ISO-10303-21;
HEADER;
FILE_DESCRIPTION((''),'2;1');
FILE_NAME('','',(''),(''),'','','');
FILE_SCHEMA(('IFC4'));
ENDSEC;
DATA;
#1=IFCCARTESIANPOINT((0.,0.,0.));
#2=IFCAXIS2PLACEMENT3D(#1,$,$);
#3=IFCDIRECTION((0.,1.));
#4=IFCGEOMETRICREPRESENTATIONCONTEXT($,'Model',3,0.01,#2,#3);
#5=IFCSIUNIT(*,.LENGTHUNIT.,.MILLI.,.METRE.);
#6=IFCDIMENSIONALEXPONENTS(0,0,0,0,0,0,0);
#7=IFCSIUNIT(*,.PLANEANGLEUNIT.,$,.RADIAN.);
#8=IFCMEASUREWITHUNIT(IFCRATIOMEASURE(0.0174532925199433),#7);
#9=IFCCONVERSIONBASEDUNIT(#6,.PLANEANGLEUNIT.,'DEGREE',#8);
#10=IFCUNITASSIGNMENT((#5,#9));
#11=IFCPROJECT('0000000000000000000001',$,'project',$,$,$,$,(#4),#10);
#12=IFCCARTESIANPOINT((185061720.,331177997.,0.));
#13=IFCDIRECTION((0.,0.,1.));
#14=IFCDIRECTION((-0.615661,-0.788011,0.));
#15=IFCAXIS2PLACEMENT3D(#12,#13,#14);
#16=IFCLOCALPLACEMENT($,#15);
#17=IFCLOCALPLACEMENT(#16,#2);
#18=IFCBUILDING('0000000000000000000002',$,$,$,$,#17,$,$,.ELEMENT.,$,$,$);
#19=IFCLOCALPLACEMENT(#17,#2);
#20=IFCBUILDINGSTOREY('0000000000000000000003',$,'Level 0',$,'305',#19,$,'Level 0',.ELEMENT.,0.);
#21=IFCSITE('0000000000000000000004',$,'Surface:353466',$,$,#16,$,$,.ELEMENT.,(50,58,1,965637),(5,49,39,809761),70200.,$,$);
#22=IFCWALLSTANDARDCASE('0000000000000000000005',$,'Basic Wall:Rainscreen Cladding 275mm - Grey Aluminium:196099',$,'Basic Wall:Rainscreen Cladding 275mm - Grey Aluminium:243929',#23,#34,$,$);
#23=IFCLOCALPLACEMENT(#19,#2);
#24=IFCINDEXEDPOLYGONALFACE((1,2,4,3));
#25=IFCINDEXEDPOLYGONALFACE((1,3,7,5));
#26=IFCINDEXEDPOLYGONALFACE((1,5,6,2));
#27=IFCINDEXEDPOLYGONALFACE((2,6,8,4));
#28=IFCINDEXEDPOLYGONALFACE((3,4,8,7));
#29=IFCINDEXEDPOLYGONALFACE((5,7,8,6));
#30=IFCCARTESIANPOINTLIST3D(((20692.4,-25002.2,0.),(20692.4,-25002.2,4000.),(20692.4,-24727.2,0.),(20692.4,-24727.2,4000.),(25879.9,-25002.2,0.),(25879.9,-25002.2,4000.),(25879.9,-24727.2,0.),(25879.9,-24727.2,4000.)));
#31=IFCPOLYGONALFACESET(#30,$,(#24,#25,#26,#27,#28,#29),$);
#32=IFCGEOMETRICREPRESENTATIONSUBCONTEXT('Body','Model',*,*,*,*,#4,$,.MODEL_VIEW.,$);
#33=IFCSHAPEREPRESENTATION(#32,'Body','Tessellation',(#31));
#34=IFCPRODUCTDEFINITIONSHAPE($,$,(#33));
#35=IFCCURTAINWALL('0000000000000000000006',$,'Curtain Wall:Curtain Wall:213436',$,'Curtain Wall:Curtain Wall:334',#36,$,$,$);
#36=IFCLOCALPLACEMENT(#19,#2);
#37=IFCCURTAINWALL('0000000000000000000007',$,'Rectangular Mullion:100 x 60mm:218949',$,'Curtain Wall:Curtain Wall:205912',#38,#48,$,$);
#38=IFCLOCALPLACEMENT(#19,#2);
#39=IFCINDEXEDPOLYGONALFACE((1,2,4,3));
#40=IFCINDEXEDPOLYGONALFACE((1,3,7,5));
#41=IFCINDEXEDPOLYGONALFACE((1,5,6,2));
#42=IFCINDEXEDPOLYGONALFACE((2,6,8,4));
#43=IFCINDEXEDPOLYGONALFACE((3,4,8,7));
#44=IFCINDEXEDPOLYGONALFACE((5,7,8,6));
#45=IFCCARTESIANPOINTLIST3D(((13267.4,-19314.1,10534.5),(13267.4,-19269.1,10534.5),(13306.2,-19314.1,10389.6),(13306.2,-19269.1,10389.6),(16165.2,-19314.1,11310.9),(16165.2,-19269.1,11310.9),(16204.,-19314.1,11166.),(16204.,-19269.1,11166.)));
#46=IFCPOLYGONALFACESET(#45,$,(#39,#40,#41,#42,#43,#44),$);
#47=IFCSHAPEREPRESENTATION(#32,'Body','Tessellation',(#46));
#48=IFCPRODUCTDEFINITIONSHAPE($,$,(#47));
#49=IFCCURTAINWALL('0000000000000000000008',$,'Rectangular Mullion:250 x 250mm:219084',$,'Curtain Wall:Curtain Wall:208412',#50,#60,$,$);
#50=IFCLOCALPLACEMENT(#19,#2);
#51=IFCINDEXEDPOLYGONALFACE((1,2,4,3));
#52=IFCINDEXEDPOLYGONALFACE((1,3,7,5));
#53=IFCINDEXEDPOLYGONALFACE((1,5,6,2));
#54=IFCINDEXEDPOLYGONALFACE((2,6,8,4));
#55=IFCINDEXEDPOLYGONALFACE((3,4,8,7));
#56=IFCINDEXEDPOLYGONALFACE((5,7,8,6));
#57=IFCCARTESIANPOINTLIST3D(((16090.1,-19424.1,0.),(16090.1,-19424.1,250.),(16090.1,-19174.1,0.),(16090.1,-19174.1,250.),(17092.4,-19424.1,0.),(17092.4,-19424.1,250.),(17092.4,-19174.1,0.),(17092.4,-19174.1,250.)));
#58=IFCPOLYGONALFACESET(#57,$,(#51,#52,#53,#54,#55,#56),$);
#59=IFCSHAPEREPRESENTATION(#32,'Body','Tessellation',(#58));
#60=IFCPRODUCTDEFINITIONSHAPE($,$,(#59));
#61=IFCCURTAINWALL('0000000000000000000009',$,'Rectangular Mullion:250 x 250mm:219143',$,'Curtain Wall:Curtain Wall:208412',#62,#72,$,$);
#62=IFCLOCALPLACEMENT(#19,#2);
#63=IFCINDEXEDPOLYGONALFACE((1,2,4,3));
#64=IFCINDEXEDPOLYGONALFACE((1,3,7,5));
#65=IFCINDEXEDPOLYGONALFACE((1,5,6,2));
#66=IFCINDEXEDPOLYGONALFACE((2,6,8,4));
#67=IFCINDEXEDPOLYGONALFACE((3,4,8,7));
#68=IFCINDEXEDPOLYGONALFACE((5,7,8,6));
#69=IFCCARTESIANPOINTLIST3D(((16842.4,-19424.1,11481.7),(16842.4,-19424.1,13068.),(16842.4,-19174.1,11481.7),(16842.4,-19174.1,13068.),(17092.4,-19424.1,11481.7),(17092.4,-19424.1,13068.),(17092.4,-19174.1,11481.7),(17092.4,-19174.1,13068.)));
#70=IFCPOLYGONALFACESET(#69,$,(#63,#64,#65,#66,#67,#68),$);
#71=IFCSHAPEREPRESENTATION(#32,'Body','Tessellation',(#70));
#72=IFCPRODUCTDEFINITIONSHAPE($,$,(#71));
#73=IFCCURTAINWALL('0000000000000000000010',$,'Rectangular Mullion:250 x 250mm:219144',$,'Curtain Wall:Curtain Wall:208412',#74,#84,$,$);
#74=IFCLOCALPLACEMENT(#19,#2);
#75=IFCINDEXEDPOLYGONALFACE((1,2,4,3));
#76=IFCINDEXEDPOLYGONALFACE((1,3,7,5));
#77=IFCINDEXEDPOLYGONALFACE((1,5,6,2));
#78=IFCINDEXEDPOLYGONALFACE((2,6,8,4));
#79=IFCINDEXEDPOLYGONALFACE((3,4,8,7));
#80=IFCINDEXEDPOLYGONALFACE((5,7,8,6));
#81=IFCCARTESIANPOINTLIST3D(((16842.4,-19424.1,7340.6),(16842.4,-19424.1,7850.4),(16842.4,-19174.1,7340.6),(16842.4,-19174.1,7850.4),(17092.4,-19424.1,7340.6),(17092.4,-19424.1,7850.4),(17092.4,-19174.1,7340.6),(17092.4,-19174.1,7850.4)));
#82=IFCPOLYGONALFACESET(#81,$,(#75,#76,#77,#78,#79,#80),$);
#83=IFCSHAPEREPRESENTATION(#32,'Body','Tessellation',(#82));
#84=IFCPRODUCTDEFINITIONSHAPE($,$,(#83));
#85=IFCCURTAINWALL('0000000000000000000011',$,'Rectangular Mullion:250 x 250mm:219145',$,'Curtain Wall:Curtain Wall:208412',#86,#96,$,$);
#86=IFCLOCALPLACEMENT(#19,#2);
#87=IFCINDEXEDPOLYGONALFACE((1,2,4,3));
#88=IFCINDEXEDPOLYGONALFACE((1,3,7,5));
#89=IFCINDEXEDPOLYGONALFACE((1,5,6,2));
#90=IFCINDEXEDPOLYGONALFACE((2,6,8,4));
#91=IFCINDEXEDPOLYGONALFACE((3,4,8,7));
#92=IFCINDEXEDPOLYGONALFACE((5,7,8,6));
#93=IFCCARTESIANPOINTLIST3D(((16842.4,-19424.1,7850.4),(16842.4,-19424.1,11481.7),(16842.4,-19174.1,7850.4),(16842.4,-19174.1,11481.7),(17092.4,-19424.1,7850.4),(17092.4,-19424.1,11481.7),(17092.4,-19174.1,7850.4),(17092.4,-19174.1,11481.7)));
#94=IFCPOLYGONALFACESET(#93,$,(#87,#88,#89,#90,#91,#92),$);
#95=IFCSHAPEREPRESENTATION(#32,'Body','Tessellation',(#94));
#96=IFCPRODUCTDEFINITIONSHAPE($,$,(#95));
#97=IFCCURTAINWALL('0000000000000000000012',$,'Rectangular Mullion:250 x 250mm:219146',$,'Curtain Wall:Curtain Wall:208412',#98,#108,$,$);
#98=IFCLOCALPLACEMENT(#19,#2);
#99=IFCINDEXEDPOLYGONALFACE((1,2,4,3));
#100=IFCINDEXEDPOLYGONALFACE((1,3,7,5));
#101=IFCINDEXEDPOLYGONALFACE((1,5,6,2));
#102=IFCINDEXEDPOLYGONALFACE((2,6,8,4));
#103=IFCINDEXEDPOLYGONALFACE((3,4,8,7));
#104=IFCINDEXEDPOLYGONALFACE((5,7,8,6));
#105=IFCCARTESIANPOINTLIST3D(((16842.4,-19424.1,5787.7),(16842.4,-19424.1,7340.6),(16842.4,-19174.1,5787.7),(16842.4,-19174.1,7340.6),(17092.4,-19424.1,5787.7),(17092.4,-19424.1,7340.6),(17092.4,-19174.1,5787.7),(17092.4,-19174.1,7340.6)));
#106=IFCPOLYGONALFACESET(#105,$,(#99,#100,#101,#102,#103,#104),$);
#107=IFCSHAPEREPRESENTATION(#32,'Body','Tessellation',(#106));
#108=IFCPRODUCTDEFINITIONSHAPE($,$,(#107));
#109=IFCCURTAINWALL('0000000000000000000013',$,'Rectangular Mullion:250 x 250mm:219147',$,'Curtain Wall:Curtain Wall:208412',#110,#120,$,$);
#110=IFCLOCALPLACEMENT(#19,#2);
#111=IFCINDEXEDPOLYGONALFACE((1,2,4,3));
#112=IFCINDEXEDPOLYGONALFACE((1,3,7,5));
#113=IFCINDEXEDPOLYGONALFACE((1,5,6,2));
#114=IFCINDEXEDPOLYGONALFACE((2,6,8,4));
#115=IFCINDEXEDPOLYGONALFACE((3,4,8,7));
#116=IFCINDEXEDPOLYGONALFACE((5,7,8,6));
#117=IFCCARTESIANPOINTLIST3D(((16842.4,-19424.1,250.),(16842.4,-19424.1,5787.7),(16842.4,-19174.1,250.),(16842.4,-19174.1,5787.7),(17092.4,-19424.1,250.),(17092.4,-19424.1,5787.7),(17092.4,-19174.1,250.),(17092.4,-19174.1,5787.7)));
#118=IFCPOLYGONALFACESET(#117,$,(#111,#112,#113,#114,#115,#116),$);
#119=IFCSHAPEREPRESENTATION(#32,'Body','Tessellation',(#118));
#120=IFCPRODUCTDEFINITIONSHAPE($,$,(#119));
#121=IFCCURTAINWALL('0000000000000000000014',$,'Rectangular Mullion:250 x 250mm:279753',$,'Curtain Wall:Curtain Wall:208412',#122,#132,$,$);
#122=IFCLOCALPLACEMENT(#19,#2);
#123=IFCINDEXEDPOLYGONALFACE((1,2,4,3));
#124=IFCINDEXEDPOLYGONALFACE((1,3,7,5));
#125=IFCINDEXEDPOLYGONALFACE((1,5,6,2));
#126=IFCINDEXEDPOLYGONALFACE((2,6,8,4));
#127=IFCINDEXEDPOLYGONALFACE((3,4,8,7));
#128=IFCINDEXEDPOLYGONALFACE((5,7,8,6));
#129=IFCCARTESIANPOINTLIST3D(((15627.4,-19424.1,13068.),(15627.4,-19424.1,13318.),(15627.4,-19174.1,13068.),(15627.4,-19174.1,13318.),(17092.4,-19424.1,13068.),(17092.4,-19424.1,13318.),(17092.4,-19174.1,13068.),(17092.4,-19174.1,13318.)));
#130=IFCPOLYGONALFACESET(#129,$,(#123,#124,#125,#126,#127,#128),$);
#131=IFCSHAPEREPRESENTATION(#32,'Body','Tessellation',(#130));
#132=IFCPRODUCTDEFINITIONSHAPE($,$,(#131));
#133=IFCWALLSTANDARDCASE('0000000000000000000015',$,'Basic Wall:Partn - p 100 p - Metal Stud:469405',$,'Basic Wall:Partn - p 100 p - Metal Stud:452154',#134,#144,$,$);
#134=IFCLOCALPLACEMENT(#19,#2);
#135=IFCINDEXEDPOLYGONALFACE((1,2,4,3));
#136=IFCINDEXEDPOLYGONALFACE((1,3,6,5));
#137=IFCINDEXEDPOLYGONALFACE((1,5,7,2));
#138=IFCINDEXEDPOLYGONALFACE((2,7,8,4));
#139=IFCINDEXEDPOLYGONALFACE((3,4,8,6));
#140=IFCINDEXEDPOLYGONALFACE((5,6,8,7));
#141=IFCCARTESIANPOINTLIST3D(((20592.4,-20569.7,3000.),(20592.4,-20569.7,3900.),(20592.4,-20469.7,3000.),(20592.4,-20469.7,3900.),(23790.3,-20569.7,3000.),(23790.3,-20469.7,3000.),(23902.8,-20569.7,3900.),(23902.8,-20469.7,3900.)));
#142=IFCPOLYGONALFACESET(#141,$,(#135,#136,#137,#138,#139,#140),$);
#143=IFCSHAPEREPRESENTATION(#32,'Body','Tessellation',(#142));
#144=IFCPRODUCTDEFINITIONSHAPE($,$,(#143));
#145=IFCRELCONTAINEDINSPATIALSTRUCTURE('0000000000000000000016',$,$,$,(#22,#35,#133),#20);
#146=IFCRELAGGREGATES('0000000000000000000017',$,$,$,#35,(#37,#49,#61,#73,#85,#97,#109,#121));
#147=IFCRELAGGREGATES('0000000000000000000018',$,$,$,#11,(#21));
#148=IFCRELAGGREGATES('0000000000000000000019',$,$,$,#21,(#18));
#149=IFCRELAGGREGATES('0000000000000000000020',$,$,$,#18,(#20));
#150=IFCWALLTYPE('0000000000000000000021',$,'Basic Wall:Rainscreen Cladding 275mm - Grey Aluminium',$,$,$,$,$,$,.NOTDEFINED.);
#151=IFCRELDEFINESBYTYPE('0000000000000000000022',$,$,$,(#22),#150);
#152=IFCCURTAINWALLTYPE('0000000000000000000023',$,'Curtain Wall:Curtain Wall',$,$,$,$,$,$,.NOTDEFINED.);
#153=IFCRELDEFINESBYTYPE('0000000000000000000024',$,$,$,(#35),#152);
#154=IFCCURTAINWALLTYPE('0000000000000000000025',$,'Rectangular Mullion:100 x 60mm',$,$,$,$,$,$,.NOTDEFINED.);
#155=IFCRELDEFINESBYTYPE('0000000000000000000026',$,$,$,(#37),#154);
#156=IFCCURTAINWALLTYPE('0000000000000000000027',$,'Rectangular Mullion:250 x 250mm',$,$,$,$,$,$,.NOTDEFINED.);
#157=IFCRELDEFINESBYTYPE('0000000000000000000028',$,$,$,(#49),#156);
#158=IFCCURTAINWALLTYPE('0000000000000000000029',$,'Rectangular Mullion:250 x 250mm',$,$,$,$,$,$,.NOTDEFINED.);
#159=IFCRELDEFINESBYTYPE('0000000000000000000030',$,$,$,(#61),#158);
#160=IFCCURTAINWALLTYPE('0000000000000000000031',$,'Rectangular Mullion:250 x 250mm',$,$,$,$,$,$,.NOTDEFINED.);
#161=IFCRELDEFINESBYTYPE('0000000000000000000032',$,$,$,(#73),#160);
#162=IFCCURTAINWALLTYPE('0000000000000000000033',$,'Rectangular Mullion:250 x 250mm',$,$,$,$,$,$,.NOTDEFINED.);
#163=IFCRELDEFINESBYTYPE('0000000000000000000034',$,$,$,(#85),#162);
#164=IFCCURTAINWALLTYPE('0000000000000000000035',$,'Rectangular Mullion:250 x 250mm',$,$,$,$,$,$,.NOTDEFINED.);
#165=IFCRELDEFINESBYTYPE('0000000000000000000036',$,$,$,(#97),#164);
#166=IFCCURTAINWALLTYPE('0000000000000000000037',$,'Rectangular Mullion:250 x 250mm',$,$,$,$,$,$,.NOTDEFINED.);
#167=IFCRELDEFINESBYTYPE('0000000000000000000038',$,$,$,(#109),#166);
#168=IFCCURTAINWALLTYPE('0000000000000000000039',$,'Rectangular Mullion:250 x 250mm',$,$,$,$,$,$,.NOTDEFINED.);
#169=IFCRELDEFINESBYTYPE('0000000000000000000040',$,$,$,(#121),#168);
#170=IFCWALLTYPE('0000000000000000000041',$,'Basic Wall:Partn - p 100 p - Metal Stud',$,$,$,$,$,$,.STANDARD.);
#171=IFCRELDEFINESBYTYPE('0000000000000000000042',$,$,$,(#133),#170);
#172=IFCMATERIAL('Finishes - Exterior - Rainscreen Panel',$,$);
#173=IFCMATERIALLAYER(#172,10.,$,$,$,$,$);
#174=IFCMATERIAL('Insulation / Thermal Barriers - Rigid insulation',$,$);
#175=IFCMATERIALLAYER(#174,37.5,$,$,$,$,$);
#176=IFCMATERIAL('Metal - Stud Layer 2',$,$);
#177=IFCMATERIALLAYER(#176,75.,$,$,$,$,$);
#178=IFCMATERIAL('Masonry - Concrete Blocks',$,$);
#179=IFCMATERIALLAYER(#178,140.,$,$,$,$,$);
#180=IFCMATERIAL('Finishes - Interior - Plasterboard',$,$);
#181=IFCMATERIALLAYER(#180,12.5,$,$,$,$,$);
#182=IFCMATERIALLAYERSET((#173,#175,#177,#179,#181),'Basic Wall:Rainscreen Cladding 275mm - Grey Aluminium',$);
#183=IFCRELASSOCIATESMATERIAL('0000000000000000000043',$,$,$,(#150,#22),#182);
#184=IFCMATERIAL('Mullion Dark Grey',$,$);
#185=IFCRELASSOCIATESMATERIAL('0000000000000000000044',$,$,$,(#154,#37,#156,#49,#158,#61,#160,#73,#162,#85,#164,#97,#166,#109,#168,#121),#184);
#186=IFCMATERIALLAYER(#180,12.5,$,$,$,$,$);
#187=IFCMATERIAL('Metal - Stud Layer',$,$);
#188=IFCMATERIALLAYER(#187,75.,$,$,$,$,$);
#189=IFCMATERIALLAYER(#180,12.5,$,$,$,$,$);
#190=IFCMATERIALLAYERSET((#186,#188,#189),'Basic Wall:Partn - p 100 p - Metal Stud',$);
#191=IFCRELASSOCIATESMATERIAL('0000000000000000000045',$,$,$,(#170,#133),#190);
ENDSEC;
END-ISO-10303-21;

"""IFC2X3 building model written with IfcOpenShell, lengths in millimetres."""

from ifc_helpers import new_model, entity, si_unit, converted_unit, direction, frame, frame_2d, origin, origin_2d_with_axis, place, context, subcontext, project, spatial, rectangle, extrude, clip, halfspace, source, transform, mapped, material, layer, layer_set, layer_usage, type_object, type_shapes, element, aggregate, save


model = new_model("IFC2X3")

# Units and contexts
model_context = context("Model", 3, precision=0.01, world=origin(), true_north=direction((0.0, 1.0)))
body_context = subcontext(model_context, "Body", "Model", "MODEL_VIEW")
ifc_project = project(units=[si_unit("LENGTHUNIT", "METRE", prefix="MILLI"), converted_unit("PLANEANGLEUNIT", "DEGREE", entity("IfcRatioMeasure", 0.0174532925199433), si_unit("PLANEANGLEUNIT", "RADIAN"), dimensions=[0, 0, 0, 0, 0, 0, 0])], contexts=[model_context])

# Site, building, storey
site_placement = place(None, frame((185061720.0, 331177997.0, 0.0), z_axis=(0.0, 0.0, 1.0), x_axis=(-0.615661, -0.788011, 0.0)))
site = spatial("IfcSite", under=ifc_project, at=site_placement, Name="Surface:353466", CompositionType="ELEMENT", RefLatitude=(50, 58, 1, 965637), RefLongitude=(5, 49, 39, 809761), RefElevation=70200.0)
building_placement = place(site_placement, origin())
building = spatial("IfcBuilding", under=site, at=building_placement, CompositionType="ELEMENT")
storey_placement = place(building_placement, origin())
storey = spatial("IfcBuildingStorey", under=building, at=storey_placement, Name="Level 0", ObjectType="305", LongName="Level 0", CompositionType="ELEMENT", Elevation=0.0)

# Wall
ifc_material_1 = material(Name="Finishes - Exterior - Rainscreen Panel")
ifc_layer_1 = layer(ifc_material_1, 10.0)
ifc_material_2 = material(Name="Insulation / Thermal Barriers - Rigid insulation")
ifc_layer_2 = layer(ifc_material_2, 37.5)
ifc_material_3 = material(Name="Metal - Stud Layer 2")
ifc_layer_3 = layer(ifc_material_3, 75.0)
ifc_material_4 = material(Name="Masonry - Concrete Blocks")
ifc_layer_4 = layer(ifc_material_4, 140.0)
ifc_material_5 = material(Name="Finishes - Interior - Plasterboard")
ifc_layer_5 = layer(ifc_material_5, 12.5)
ifc_layer_set_1 = layer_set([ifc_layer_1, ifc_layer_2, ifc_layer_3, ifc_layer_4, ifc_layer_5], Name="Basic Wall:Rainscreen Cladding 275mm - Grey Aluminium")
ifc_layer_usage_1 = layer_usage(ifc_layer_set_1, "AXIS2", "POSITIVE", -137.5)
wall_type_1 = type_object("IfcWallType", Name="Basic Wall:Rainscreen Cladding 275mm - Grey Aluminium", PredefinedType="NOTDEFINED", material=ifc_layer_set_1)
wall_1_placement = place(storey_placement, frame((20692.4, -24864.7, 0.0)))
element("IfcWallStandardCase", 1, at=wall_1_placement, inside=storey, type_object=wall_type_1, material=ifc_layer_usage_1, Name="Basic Wall:Rainscreen Cladding 275mm - Grey Aluminium:196099", ObjectType="Basic Wall:Rainscreen Cladding 275mm - Grey Aluminium:243929", context=body_context, shape_type="Clipping", body=[
    clip(extrude(rectangle(XDim=5187.5, YDim=275.0, at=frame_2d((2593.8, 0.0), x_axis=(-1.0, 0.0))), origin(), (0.0, 0.0, 1.0), 4000.0), halfspace(frame((0.0, 0.0, -738.5)), True)),
])

# Curtain walls
curtain_wall_type_1 = type_object("IfcCurtainWallType", Name="Curtain Wall:Curtain Wall", PredefinedType="NOTDEFINED")
curtain_wall_1_placement = place(storey_placement, origin())
curtain_wall_1 = element("IfcCurtainWall", 2, at=curtain_wall_1_placement, inside=storey, type_object=curtain_wall_type_1, Name="Curtain Wall:Curtain Wall:213436", ObjectType="Curtain Wall:Curtain Wall:334")
ifc_material_6 = material(Name="Mullion Dark Grey")
curtain_wall_type_2 = type_object("IfcCurtainWallType", Name="Rectangular Mullion:100 x 60mm", PredefinedType="NOTDEFINED", material=ifc_material_6)
shared_shape_1 = source(origin(), body_context, "Body", "SweptSolid", [
    extrude(rectangle(XDim=150.0, YDim=45.0, at=frame_2d((0.0, 0.0), x_axis=(1.0, 0.0))), frame((0.0, -7.5, -3000.0)), (0.0, 0.0, 1.0), 3000.0),
])
type_shapes(curtain_wall_type_2, [shared_shape_1])
curtain_wall_2_placement = place(storey_placement, frame((16184.6, -19299.1, 11238.5), z_axis=(0.965926, 0.0, 0.258819), x_axis=(-0.258819, 0.0, 0.965926)))
curtain_wall_2 = element("IfcCurtainWall", 3, at=curtain_wall_2_placement, type_object=curtain_wall_type_2, material=ifc_material_6, Name="Rectangular Mullion:100 x 60mm:218949", ObjectType="Curtain Wall:Curtain Wall:205912", context=body_context, shape_type="MappedRepresentation", body=[
    mapped(shared_shape_1, transform((0.0, 0.0, 0.0), scale=1.0)),
])
curtain_wall_type_3 = type_object("IfcCurtainWallType", Name="Rectangular Mullion:250 x 250mm", PredefinedType="NOTDEFINED", material=ifc_material_6)
shared_shape_2 = source(origin(), body_context, "Body", "SweptSolid", [
    extrude(rectangle(XDim=250.0, YDim=250.0, at=origin_2d_with_axis()), frame((-125.0, 0.0, -1002.3), z_axis=(0.0, 0.0, 1.0), x_axis=(-1.0, 0.0, 0.0)), (0.0, 0.0, 1.0), 1002.3),
])
type_shapes(curtain_wall_type_3, [shared_shape_2])
curtain_wall_3_placement = place(storey_placement, frame((16090.1, -19299.1, 0.0), z_axis=(-1.0, 0.0, 0.0), x_axis=(0.0, 0.0, -1.0)))
curtain_wall_3 = element("IfcCurtainWall", 4, at=curtain_wall_3_placement, type_object=curtain_wall_type_3, material=ifc_material_6, Name="Rectangular Mullion:250 x 250mm:219084", ObjectType="Curtain Wall:Curtain Wall:208412", context=body_context, shape_type="MappedRepresentation", body=[
    mapped(shared_shape_2, transform((0.0, 0.0, 0.0), scale=1.0)),
])
curtain_wall_type_4 = type_object("IfcCurtainWallType", Name="Rectangular Mullion:250 x 250mm", PredefinedType="NOTDEFINED", material=ifc_material_6)
shared_shape_3 = source(origin(), body_context, "Body", "SweptSolid", [
    extrude(rectangle(XDim=250.0, YDim=250.0, at=origin_2d_with_axis()), frame((-125.0, 0.0, -1586.2), z_axis=(0.0, 0.0, 1.0), x_axis=(-1.0, 0.0, 0.0)), (0.0, 0.0, 1.0), 1586.2),
])
type_shapes(curtain_wall_type_4, [shared_shape_3])
curtain_wall_4_placement = place(storey_placement, frame((17092.4, -19299.1, 11481.7), z_axis=(0.0, 0.0, -1.0), x_axis=(1.0, 0.0, 0.0)))
curtain_wall_4 = element("IfcCurtainWall", 5, at=curtain_wall_4_placement, type_object=curtain_wall_type_4, material=ifc_material_6, Name="Rectangular Mullion:250 x 250mm:219143", ObjectType="Curtain Wall:Curtain Wall:208412", context=body_context, shape_type="MappedRepresentation", body=[
    mapped(shared_shape_3, transform((0.0, 0.0, 0.0), scale=1.0)),
])
curtain_wall_type_5 = type_object("IfcCurtainWallType", Name="Rectangular Mullion:250 x 250mm", PredefinedType="NOTDEFINED", material=ifc_material_6)
shared_shape_4 = source(origin(), body_context, "Body", "SweptSolid", [
    extrude(rectangle(XDim=250.0, YDim=250.0, at=origin_2d_with_axis()), frame((-125.0, 0.0, -509.8), z_axis=(0.0, 0.0, 1.0), x_axis=(-1.0, 0.0, 0.0)), (0.0, 0.0, 1.0), 509.8),
])
type_shapes(curtain_wall_type_5, [shared_shape_4])
curtain_wall_5_placement = place(storey_placement, frame((17092.4, -19299.1, 7340.6), z_axis=(0.0, 0.0, -1.0), x_axis=(1.0, 0.0, 0.0)))
curtain_wall_5 = element("IfcCurtainWall", 6, at=curtain_wall_5_placement, type_object=curtain_wall_type_5, material=ifc_material_6, Name="Rectangular Mullion:250 x 250mm:219144", ObjectType="Curtain Wall:Curtain Wall:208412", context=body_context, shape_type="MappedRepresentation", body=[
    mapped(shared_shape_4, transform((0.0, 0.0, 0.0), scale=1.0)),
])
curtain_wall_type_6 = type_object("IfcCurtainWallType", Name="Rectangular Mullion:250 x 250mm", PredefinedType="NOTDEFINED", material=ifc_material_6)
shared_shape_5 = source(origin(), body_context, "Body", "SweptSolid", [
    extrude(rectangle(XDim=250.0, YDim=250.0, at=origin_2d_with_axis()), frame((-125.0, 0.0, -3631.3), z_axis=(0.0, 0.0, 1.0), x_axis=(-1.0, 0.0, 0.0)), (0.0, 0.0, 1.0), 3631.3),
])
type_shapes(curtain_wall_type_6, [shared_shape_5])
curtain_wall_6_placement = place(storey_placement, frame((17092.4, -19299.1, 7850.4), z_axis=(0.0, 0.0, -1.0), x_axis=(1.0, 0.0, 0.0)))
curtain_wall_6 = element("IfcCurtainWall", 7, at=curtain_wall_6_placement, type_object=curtain_wall_type_6, material=ifc_material_6, Name="Rectangular Mullion:250 x 250mm:219145", ObjectType="Curtain Wall:Curtain Wall:208412", context=body_context, shape_type="MappedRepresentation", body=[
    mapped(shared_shape_5, transform((0.0, 0.0, 0.0), scale=1.0)),
])
curtain_wall_type_7 = type_object("IfcCurtainWallType", Name="Rectangular Mullion:250 x 250mm", PredefinedType="NOTDEFINED", material=ifc_material_6)
shared_shape_6 = source(origin(), body_context, "Body", "SweptSolid", [
    extrude(rectangle(XDim=250.0, YDim=250.0, at=origin_2d_with_axis()), frame((-125.0, 0.0, -1552.9), z_axis=(0.0, 0.0, 1.0), x_axis=(-1.0, 0.0, 0.0)), (0.0, 0.0, 1.0), 1552.9),
])
type_shapes(curtain_wall_type_7, [shared_shape_6])
curtain_wall_7_placement = place(storey_placement, frame((17092.4, -19299.1, 5787.7), z_axis=(0.0, 0.0, -1.0), x_axis=(1.0, 0.0, 0.0)))
curtain_wall_7 = element("IfcCurtainWall", 8, at=curtain_wall_7_placement, type_object=curtain_wall_type_7, material=ifc_material_6, Name="Rectangular Mullion:250 x 250mm:219146", ObjectType="Curtain Wall:Curtain Wall:208412", context=body_context, shape_type="MappedRepresentation", body=[
    mapped(shared_shape_6, transform((0.0, 0.0, 0.0), scale=1.0)),
])
curtain_wall_type_8 = type_object("IfcCurtainWallType", Name="Rectangular Mullion:250 x 250mm", PredefinedType="NOTDEFINED", material=ifc_material_6)
shared_shape_7 = source(origin(), body_context, "Body", "SweptSolid", [
    extrude(rectangle(XDim=250.0, YDim=250.0, at=origin_2d_with_axis()), frame((-125.0, 0.0, -5537.7), z_axis=(0.0, 0.0, 1.0), x_axis=(-1.0, 0.0, 0.0)), (0.0, 0.0, 1.0), 5537.7),
])
type_shapes(curtain_wall_type_8, [shared_shape_7])
curtain_wall_8_placement = place(storey_placement, frame((17092.4, -19299.1, 250.0), z_axis=(0.0, 0.0, -1.0), x_axis=(1.0, 0.0, 0.0)))
curtain_wall_8 = element("IfcCurtainWall", 9, at=curtain_wall_8_placement, type_object=curtain_wall_type_8, material=ifc_material_6, Name="Rectangular Mullion:250 x 250mm:219147", ObjectType="Curtain Wall:Curtain Wall:208412", context=body_context, shape_type="MappedRepresentation", body=[
    mapped(shared_shape_7, transform((0.0, 0.0, 0.0), scale=1.0)),
])
curtain_wall_type_9 = type_object("IfcCurtainWallType", Name="Rectangular Mullion:250 x 250mm", PredefinedType="NOTDEFINED", material=ifc_material_6)
shared_shape_8 = source(origin(), body_context, "Body", "SweptSolid", [
    extrude(rectangle(XDim=250.0, YDim=250.0, at=origin_2d_with_axis()), frame((-125.0, 0.0, -1465.0), z_axis=(0.0, 0.0, 1.0), x_axis=(-1.0, 0.0, 0.0)), (0.0, 0.0, 1.0), 1465.0),
])
type_shapes(curtain_wall_type_9, [shared_shape_8])
curtain_wall_9_placement = place(storey_placement, frame((17092.4, -19299.1, 13318.0), z_axis=(1.0, 0.0, 0.0), x_axis=(0.0, 0.0, 1.0)))
curtain_wall_9 = element("IfcCurtainWall", 10, at=curtain_wall_9_placement, type_object=curtain_wall_type_9, material=ifc_material_6, Name="Rectangular Mullion:250 x 250mm:279753", ObjectType="Curtain Wall:Curtain Wall:208412", context=body_context, shape_type="MappedRepresentation", body=[
    mapped(shared_shape_8, transform((0.0, 0.0, 0.0), scale=1.0)),
])
aggregate(curtain_wall_1, [curtain_wall_2, curtain_wall_3, curtain_wall_4, curtain_wall_5, curtain_wall_6, curtain_wall_7, curtain_wall_8, curtain_wall_9])

# Wall
ifc_layer_6 = layer(ifc_material_5, 12.5)
ifc_material_7 = material(Name="Metal - Stud Layer")
ifc_layer_7 = layer(ifc_material_7, 75.0)
ifc_layer_8 = layer(ifc_material_5, 12.5)
ifc_layer_set_2 = layer_set([ifc_layer_6, ifc_layer_7, ifc_layer_8], Name="Basic Wall:Partn - p 100 p - Metal Stud")
ifc_layer_usage_2 = layer_usage(ifc_layer_set_2, "AXIS2", "POSITIVE", -50.0)
wall_type_2 = type_object("IfcWallType", Name="Basic Wall:Partn - p 100 p - Metal Stud", PredefinedType="STANDARD", material=ifc_layer_set_2)
wall_2_placement = place(storey_placement, frame((23902.8, -20519.7, 3000.0), z_axis=(0.0, 0.0, 1.0), x_axis=(-1.0, 0.0, 0.0)))
element("IfcWallStandardCase", 11, at=wall_2_placement, inside=storey, type_object=wall_type_2, material=ifc_layer_usage_2, Name="Basic Wall:Partn - p 100 p - Metal Stud:469405", ObjectType="Basic Wall:Partn - p 100 p - Metal Stud:452154", context=body_context, shape_type="Clipping", body=[
    clip(extrude(rectangle(XDim=3310.4, YDim=100.0, at=frame_2d((1655.2, 0.0), x_axis=(-1.0, 0.0))), origin(), (0.0, 0.0, 1.0), 900.0), halfspace(frame((112.5, -50.0, 0.0), z_axis=(-0.992278, 0.0, -0.124035), x_axis=(0.0, 1.0, 0.0)), False)),
])

save(model, "model.ifc")
